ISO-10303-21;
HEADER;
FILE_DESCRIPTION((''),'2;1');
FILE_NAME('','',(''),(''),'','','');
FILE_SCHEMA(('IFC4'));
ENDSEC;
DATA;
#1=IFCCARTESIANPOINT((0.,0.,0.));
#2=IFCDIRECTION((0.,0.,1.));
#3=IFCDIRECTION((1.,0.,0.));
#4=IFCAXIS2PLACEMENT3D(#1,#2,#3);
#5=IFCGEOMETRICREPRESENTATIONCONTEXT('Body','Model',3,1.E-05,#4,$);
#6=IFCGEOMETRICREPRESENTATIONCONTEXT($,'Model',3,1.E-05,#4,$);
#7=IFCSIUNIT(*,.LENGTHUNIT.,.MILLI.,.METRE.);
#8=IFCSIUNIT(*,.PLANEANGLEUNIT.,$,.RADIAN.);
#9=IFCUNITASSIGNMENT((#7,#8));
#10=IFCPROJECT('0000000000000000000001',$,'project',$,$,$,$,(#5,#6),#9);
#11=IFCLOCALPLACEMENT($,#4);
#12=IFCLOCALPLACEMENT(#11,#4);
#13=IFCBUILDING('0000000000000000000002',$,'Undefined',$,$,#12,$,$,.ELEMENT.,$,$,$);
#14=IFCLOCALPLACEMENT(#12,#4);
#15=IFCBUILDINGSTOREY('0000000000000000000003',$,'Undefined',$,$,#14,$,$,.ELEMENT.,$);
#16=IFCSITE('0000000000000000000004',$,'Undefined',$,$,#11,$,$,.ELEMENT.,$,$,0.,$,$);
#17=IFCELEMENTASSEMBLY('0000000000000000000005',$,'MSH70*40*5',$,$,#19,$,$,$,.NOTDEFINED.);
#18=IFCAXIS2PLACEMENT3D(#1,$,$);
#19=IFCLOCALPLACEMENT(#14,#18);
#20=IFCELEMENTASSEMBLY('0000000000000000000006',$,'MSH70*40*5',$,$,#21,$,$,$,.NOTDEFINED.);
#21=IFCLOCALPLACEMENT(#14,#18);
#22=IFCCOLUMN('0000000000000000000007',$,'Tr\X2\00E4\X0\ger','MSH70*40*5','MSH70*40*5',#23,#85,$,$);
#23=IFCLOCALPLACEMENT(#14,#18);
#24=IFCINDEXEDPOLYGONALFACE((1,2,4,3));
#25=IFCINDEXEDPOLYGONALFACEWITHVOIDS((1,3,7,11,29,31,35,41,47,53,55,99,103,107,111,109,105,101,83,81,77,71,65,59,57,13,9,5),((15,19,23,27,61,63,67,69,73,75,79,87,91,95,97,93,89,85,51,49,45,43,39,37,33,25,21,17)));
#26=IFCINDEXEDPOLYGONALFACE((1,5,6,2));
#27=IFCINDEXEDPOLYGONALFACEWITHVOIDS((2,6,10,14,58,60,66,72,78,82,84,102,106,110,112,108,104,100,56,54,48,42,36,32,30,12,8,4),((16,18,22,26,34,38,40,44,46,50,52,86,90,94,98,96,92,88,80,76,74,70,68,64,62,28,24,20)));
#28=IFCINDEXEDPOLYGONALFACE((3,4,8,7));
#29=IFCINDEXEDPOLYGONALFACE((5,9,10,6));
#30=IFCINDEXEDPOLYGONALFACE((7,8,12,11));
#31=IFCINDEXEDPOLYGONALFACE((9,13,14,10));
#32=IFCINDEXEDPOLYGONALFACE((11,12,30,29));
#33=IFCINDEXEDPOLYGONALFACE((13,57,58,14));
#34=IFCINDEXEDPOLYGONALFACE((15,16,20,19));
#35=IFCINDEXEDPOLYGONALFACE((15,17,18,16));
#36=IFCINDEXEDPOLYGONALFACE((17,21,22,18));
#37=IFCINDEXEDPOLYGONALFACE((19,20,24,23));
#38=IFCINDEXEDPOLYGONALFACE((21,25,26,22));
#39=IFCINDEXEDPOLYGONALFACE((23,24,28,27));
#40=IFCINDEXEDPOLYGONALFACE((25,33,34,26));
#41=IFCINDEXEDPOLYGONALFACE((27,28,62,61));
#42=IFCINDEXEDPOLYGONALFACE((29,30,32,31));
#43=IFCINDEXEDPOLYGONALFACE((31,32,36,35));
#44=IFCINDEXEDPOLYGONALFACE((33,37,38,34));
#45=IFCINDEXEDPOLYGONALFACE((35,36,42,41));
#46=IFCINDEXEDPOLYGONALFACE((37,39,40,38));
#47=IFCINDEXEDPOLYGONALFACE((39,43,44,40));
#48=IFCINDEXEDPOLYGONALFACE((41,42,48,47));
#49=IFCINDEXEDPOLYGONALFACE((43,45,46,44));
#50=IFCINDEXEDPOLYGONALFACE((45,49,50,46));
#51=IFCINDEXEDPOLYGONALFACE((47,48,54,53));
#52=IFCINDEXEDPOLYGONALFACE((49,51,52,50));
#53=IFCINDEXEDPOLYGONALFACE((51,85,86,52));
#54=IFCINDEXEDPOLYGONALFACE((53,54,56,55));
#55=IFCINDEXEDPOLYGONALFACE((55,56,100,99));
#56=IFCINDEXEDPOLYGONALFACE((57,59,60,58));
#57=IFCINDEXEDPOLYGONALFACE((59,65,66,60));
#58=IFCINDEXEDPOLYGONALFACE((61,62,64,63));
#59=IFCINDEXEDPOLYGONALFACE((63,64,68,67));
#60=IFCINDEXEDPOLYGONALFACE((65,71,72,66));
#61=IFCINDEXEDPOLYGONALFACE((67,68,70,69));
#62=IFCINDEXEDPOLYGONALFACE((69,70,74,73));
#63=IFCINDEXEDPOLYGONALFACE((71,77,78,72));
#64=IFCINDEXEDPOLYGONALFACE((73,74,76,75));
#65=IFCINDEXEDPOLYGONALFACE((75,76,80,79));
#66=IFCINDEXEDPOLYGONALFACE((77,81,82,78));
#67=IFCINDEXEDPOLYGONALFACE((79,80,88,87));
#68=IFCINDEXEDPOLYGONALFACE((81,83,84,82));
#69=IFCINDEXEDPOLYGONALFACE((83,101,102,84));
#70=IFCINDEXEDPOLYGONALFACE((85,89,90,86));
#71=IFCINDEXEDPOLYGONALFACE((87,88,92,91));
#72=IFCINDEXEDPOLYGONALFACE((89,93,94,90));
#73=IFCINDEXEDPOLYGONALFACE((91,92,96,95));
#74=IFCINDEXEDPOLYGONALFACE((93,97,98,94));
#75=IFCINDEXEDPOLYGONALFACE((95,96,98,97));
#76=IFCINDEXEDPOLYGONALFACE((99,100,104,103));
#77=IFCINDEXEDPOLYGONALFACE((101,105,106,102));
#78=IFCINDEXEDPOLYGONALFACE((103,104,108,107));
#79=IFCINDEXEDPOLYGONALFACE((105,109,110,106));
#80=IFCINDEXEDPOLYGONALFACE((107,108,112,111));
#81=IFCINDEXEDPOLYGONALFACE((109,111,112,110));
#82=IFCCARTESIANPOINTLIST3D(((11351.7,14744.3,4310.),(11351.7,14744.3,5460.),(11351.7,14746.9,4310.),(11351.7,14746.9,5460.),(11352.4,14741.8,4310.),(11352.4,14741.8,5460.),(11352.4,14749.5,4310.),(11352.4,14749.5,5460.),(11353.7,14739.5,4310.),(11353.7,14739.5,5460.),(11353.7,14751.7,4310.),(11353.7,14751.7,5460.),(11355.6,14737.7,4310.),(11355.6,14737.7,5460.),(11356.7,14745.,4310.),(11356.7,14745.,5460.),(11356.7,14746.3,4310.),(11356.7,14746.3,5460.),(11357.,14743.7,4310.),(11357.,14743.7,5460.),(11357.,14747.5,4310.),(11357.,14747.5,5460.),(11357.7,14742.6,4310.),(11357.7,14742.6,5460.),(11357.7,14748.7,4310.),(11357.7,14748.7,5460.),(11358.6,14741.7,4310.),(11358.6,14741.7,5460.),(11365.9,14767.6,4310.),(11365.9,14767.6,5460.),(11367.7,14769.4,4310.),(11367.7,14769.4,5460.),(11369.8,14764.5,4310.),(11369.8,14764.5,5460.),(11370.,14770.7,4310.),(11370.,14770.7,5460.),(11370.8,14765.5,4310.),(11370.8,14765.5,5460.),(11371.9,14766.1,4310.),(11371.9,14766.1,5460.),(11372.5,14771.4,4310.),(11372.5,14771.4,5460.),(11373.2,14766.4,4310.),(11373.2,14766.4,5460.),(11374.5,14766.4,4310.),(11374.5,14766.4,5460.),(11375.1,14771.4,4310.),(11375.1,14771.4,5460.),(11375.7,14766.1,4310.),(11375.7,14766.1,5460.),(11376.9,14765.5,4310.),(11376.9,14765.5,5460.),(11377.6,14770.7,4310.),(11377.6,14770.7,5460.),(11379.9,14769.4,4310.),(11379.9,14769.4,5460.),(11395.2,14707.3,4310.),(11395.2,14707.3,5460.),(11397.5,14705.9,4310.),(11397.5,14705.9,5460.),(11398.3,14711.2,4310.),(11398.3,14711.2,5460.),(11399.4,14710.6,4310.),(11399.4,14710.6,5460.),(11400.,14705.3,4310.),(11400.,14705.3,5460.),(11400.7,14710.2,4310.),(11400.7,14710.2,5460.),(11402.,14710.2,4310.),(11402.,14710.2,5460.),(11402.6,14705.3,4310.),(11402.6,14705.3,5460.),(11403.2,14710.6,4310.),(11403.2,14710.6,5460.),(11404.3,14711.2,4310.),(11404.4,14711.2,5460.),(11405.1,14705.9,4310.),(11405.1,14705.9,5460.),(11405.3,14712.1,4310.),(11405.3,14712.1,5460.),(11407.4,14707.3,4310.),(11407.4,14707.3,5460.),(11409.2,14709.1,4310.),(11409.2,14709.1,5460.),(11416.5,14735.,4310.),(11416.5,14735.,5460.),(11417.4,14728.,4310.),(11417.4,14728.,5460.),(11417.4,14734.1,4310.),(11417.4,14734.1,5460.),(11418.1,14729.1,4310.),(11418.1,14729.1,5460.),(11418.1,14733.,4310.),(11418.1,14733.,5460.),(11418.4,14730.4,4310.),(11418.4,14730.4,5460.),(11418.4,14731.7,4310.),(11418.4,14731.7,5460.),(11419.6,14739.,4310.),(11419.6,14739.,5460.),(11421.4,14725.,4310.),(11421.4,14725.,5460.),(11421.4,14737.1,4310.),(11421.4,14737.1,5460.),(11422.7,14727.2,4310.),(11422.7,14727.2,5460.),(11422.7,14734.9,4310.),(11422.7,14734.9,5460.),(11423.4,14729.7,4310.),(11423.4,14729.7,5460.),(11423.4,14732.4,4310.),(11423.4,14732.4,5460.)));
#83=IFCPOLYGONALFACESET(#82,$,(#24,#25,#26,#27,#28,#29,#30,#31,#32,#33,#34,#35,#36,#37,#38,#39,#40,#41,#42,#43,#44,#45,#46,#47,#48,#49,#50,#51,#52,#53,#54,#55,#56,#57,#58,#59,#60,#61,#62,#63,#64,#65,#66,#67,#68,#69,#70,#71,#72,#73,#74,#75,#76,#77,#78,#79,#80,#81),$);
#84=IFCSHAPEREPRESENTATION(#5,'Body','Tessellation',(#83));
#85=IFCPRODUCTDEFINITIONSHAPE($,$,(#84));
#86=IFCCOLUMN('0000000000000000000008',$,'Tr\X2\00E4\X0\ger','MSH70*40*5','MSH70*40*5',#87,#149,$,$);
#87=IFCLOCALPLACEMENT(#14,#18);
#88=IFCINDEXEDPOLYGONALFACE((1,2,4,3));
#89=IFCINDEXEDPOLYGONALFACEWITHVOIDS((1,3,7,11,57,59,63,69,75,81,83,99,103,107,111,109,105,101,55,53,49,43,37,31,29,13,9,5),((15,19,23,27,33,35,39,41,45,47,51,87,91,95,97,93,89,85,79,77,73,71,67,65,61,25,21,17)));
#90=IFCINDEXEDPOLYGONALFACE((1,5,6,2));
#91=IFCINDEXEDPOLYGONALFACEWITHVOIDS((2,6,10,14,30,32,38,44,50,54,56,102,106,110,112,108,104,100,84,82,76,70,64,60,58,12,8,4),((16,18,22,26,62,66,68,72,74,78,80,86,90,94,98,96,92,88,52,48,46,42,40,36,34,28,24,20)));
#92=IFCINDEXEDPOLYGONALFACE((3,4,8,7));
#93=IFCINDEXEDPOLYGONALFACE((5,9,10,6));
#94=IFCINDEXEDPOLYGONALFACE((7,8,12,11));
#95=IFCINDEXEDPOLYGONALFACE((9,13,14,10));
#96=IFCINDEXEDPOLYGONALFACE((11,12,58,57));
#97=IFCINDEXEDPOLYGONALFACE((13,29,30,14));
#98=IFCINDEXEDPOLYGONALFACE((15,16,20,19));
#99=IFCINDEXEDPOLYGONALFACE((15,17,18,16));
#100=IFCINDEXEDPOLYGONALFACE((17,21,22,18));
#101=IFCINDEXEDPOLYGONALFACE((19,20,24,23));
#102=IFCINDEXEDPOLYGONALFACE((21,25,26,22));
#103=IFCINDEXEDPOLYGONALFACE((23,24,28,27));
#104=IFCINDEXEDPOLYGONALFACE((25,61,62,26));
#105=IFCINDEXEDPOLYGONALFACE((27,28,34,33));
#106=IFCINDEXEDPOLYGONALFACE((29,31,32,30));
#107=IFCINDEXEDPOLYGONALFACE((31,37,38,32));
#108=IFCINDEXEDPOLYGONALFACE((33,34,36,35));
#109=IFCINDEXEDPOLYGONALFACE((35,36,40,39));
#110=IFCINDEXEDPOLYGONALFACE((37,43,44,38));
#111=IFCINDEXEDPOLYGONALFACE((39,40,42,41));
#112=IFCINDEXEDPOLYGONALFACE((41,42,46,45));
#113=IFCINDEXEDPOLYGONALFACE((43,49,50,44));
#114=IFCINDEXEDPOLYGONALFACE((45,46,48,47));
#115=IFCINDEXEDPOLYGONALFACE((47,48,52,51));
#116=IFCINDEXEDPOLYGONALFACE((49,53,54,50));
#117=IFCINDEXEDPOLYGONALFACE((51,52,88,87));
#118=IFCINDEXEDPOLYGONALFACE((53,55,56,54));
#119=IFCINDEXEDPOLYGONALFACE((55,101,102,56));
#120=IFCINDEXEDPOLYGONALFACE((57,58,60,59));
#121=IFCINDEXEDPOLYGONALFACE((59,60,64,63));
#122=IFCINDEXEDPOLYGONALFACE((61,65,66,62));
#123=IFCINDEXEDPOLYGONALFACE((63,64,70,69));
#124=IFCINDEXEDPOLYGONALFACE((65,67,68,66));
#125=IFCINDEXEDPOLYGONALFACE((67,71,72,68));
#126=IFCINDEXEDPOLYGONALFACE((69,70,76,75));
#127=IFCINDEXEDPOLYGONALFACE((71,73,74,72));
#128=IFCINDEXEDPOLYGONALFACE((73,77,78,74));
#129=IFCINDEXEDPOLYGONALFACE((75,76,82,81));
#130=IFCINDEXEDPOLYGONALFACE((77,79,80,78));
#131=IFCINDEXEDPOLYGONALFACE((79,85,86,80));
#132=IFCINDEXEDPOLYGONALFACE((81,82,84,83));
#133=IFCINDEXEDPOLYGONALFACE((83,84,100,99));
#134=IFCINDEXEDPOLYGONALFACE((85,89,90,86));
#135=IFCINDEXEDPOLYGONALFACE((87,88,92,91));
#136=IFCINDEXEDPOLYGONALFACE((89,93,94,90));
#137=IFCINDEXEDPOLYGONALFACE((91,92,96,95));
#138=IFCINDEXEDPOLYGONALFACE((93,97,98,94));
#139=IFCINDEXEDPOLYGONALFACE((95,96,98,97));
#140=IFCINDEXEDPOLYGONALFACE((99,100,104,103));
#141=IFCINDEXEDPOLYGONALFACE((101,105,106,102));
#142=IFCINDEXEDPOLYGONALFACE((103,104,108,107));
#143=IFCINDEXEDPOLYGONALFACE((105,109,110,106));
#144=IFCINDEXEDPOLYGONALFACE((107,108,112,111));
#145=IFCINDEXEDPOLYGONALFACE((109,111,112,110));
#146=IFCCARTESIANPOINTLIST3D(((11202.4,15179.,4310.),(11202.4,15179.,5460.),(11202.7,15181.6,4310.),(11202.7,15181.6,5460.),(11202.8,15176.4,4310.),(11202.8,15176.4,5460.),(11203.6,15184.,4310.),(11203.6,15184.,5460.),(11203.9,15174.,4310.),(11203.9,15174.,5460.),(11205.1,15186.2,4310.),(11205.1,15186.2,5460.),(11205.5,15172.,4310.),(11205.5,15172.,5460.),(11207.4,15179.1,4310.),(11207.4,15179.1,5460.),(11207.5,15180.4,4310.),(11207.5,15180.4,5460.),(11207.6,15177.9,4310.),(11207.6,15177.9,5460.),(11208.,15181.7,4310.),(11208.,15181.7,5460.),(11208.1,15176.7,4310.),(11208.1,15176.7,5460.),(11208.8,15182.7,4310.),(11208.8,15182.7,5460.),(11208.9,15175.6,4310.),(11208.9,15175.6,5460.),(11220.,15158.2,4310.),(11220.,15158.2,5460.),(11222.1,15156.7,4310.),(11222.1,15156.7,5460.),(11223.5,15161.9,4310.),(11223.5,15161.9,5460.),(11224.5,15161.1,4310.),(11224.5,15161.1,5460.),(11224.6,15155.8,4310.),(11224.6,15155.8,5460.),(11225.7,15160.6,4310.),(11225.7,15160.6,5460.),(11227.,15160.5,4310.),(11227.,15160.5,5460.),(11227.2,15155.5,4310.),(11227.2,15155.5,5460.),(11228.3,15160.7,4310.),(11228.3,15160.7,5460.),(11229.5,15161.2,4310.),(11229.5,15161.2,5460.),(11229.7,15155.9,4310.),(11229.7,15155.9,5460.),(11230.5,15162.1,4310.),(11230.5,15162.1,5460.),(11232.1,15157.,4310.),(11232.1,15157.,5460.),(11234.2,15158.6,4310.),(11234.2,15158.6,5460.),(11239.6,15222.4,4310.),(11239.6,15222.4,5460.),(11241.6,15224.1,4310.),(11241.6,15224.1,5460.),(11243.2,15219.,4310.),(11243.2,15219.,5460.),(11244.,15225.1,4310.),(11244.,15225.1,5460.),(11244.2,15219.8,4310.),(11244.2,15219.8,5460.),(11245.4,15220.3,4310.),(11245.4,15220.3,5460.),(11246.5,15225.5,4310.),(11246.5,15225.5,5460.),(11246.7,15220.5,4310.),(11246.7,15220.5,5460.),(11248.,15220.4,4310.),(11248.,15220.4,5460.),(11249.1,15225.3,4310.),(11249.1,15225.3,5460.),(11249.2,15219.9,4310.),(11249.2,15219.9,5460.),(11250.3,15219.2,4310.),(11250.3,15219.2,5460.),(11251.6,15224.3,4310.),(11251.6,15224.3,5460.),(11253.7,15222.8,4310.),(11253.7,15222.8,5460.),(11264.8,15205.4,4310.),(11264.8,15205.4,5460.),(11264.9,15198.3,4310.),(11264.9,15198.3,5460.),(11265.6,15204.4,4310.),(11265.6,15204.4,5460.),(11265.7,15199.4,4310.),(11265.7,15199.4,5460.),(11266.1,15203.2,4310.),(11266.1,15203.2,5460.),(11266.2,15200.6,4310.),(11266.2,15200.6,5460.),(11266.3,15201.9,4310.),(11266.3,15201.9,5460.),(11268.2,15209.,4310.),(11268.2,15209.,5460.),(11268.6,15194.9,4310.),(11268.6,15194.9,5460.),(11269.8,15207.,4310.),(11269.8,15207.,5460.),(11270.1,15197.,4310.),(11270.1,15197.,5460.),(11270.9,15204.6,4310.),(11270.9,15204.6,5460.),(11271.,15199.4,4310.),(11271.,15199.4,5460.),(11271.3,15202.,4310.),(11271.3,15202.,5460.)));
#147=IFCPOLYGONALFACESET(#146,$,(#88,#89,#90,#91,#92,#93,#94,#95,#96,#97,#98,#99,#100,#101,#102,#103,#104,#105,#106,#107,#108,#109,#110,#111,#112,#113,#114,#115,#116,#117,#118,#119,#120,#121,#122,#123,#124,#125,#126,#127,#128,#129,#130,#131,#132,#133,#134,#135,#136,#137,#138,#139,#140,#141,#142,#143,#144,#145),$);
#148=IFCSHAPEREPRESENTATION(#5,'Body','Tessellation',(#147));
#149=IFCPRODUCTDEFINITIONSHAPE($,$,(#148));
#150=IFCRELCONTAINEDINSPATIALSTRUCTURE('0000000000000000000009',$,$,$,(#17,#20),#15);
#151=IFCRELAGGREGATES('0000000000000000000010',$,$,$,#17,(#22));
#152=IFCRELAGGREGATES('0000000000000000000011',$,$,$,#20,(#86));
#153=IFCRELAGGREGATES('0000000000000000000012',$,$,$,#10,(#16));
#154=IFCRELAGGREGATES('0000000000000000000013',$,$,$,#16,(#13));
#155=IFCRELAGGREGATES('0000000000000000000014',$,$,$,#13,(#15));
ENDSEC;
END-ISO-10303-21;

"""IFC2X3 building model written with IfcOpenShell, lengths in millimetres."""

from ifc_helpers import new_model, si_unit, frame, origin_with_axes, origin_2d_with_axis, place, context, project, spatial, hollow_rectangle, extrude, element, aggregate, save


model = new_model("IFC2X3")

# Units and contexts
model_context_1 = context("Model", 3, precision=1e-05, world=origin_with_axes(), identifier="Body")
model_context_2 = context("Model", 3, precision=1e-05, world=origin_with_axes())
ifc_project = project(units=[si_unit("LENGTHUNIT", "METRE", prefix="MILLI"), si_unit("PLANEANGLEUNIT", "RADIAN")], contexts=[model_context_1, model_context_2])

# Site, building, storey
site_placement = place(None, origin_with_axes())
site = spatial("IfcSite", under=ifc_project, at=site_placement, Name="Undefined", CompositionType="ELEMENT", RefElevation=0.0)
building_placement = place(site_placement, origin_with_axes())
building = spatial("IfcBuilding", under=site, at=building_placement, Name="Undefined", CompositionType="ELEMENT")
storey_placement = place(building_placement, origin_with_axes())
storey = spatial("IfcBuildingStorey", under=building, at=storey_placement, Name="Undefined", CompositionType="ELEMENT")

# Element assembly
assembly_1 = element("IfcElementAssembly", 1, inside=storey, Name="MSH70*40*5", PredefinedType="NOTDEFINED")

# Element assembly
assembly_2 = element("IfcElementAssembly", 2, inside=storey, Name="MSH70*40*5", PredefinedType="NOTDEFINED")

# Columns
column_1_placement = place(storey_placement, frame((11387.6, 14738.3, 4310.0), z_axis=(0.0, 0.0, 1.0), x_axis=(1.0, 0.0, 0.0)))
column_1 = element("IfcColumn", 3, at=column_1_placement, Name="Träger", Description="MSH70*40*5", ObjectType="MSH70*40*5", context=model_context_1, shape_type="SweptSolid", body=[
    extrude(hollow_rectangle(XDim=40.0, YDim=70.0, WallThickness=5.0, InnerFilletRadius=5.0, OuterFilletRadius=10.0, at=origin_2d_with_axis()), frame((0.0, 0.0, 1150.0), z_axis=(0.0, 0.0, -1.0), x_axis=(-0.608762, -0.793353, 0.0)), (0.0, 0.0, 1.0), 1150.0),
])
aggregate(assembly_1, [column_1])
column_2_placement = place(storey_placement, frame((11236.9, 15190.5, 4310.0), z_axis=(0.0, 0.0, 1.0), x_axis=(1.0, 0.0, 0.0)))
column_2 = element("IfcColumn", 4, at=column_2_placement, Name="Träger", Description="MSH70*40*5", ObjectType="MSH70*40*5", context=model_context_1, shape_type="SweptSolid", body=[
    extrude(hollow_rectangle(XDim=40.0, YDim=70.0, WallThickness=5.0, InnerFilletRadius=5.0, OuterFilletRadius=10.0, at=origin_2d_with_axis()), frame((0.0, 0.0, 1150.0), z_axis=(0.0, 0.0, -1.0), x_axis=(0.725374, -0.688355, 0.0)), (0.0, 0.0, 1.0), 1150.0),
])
aggregate(assembly_2, [column_2])

save(model, "model.ifc")
